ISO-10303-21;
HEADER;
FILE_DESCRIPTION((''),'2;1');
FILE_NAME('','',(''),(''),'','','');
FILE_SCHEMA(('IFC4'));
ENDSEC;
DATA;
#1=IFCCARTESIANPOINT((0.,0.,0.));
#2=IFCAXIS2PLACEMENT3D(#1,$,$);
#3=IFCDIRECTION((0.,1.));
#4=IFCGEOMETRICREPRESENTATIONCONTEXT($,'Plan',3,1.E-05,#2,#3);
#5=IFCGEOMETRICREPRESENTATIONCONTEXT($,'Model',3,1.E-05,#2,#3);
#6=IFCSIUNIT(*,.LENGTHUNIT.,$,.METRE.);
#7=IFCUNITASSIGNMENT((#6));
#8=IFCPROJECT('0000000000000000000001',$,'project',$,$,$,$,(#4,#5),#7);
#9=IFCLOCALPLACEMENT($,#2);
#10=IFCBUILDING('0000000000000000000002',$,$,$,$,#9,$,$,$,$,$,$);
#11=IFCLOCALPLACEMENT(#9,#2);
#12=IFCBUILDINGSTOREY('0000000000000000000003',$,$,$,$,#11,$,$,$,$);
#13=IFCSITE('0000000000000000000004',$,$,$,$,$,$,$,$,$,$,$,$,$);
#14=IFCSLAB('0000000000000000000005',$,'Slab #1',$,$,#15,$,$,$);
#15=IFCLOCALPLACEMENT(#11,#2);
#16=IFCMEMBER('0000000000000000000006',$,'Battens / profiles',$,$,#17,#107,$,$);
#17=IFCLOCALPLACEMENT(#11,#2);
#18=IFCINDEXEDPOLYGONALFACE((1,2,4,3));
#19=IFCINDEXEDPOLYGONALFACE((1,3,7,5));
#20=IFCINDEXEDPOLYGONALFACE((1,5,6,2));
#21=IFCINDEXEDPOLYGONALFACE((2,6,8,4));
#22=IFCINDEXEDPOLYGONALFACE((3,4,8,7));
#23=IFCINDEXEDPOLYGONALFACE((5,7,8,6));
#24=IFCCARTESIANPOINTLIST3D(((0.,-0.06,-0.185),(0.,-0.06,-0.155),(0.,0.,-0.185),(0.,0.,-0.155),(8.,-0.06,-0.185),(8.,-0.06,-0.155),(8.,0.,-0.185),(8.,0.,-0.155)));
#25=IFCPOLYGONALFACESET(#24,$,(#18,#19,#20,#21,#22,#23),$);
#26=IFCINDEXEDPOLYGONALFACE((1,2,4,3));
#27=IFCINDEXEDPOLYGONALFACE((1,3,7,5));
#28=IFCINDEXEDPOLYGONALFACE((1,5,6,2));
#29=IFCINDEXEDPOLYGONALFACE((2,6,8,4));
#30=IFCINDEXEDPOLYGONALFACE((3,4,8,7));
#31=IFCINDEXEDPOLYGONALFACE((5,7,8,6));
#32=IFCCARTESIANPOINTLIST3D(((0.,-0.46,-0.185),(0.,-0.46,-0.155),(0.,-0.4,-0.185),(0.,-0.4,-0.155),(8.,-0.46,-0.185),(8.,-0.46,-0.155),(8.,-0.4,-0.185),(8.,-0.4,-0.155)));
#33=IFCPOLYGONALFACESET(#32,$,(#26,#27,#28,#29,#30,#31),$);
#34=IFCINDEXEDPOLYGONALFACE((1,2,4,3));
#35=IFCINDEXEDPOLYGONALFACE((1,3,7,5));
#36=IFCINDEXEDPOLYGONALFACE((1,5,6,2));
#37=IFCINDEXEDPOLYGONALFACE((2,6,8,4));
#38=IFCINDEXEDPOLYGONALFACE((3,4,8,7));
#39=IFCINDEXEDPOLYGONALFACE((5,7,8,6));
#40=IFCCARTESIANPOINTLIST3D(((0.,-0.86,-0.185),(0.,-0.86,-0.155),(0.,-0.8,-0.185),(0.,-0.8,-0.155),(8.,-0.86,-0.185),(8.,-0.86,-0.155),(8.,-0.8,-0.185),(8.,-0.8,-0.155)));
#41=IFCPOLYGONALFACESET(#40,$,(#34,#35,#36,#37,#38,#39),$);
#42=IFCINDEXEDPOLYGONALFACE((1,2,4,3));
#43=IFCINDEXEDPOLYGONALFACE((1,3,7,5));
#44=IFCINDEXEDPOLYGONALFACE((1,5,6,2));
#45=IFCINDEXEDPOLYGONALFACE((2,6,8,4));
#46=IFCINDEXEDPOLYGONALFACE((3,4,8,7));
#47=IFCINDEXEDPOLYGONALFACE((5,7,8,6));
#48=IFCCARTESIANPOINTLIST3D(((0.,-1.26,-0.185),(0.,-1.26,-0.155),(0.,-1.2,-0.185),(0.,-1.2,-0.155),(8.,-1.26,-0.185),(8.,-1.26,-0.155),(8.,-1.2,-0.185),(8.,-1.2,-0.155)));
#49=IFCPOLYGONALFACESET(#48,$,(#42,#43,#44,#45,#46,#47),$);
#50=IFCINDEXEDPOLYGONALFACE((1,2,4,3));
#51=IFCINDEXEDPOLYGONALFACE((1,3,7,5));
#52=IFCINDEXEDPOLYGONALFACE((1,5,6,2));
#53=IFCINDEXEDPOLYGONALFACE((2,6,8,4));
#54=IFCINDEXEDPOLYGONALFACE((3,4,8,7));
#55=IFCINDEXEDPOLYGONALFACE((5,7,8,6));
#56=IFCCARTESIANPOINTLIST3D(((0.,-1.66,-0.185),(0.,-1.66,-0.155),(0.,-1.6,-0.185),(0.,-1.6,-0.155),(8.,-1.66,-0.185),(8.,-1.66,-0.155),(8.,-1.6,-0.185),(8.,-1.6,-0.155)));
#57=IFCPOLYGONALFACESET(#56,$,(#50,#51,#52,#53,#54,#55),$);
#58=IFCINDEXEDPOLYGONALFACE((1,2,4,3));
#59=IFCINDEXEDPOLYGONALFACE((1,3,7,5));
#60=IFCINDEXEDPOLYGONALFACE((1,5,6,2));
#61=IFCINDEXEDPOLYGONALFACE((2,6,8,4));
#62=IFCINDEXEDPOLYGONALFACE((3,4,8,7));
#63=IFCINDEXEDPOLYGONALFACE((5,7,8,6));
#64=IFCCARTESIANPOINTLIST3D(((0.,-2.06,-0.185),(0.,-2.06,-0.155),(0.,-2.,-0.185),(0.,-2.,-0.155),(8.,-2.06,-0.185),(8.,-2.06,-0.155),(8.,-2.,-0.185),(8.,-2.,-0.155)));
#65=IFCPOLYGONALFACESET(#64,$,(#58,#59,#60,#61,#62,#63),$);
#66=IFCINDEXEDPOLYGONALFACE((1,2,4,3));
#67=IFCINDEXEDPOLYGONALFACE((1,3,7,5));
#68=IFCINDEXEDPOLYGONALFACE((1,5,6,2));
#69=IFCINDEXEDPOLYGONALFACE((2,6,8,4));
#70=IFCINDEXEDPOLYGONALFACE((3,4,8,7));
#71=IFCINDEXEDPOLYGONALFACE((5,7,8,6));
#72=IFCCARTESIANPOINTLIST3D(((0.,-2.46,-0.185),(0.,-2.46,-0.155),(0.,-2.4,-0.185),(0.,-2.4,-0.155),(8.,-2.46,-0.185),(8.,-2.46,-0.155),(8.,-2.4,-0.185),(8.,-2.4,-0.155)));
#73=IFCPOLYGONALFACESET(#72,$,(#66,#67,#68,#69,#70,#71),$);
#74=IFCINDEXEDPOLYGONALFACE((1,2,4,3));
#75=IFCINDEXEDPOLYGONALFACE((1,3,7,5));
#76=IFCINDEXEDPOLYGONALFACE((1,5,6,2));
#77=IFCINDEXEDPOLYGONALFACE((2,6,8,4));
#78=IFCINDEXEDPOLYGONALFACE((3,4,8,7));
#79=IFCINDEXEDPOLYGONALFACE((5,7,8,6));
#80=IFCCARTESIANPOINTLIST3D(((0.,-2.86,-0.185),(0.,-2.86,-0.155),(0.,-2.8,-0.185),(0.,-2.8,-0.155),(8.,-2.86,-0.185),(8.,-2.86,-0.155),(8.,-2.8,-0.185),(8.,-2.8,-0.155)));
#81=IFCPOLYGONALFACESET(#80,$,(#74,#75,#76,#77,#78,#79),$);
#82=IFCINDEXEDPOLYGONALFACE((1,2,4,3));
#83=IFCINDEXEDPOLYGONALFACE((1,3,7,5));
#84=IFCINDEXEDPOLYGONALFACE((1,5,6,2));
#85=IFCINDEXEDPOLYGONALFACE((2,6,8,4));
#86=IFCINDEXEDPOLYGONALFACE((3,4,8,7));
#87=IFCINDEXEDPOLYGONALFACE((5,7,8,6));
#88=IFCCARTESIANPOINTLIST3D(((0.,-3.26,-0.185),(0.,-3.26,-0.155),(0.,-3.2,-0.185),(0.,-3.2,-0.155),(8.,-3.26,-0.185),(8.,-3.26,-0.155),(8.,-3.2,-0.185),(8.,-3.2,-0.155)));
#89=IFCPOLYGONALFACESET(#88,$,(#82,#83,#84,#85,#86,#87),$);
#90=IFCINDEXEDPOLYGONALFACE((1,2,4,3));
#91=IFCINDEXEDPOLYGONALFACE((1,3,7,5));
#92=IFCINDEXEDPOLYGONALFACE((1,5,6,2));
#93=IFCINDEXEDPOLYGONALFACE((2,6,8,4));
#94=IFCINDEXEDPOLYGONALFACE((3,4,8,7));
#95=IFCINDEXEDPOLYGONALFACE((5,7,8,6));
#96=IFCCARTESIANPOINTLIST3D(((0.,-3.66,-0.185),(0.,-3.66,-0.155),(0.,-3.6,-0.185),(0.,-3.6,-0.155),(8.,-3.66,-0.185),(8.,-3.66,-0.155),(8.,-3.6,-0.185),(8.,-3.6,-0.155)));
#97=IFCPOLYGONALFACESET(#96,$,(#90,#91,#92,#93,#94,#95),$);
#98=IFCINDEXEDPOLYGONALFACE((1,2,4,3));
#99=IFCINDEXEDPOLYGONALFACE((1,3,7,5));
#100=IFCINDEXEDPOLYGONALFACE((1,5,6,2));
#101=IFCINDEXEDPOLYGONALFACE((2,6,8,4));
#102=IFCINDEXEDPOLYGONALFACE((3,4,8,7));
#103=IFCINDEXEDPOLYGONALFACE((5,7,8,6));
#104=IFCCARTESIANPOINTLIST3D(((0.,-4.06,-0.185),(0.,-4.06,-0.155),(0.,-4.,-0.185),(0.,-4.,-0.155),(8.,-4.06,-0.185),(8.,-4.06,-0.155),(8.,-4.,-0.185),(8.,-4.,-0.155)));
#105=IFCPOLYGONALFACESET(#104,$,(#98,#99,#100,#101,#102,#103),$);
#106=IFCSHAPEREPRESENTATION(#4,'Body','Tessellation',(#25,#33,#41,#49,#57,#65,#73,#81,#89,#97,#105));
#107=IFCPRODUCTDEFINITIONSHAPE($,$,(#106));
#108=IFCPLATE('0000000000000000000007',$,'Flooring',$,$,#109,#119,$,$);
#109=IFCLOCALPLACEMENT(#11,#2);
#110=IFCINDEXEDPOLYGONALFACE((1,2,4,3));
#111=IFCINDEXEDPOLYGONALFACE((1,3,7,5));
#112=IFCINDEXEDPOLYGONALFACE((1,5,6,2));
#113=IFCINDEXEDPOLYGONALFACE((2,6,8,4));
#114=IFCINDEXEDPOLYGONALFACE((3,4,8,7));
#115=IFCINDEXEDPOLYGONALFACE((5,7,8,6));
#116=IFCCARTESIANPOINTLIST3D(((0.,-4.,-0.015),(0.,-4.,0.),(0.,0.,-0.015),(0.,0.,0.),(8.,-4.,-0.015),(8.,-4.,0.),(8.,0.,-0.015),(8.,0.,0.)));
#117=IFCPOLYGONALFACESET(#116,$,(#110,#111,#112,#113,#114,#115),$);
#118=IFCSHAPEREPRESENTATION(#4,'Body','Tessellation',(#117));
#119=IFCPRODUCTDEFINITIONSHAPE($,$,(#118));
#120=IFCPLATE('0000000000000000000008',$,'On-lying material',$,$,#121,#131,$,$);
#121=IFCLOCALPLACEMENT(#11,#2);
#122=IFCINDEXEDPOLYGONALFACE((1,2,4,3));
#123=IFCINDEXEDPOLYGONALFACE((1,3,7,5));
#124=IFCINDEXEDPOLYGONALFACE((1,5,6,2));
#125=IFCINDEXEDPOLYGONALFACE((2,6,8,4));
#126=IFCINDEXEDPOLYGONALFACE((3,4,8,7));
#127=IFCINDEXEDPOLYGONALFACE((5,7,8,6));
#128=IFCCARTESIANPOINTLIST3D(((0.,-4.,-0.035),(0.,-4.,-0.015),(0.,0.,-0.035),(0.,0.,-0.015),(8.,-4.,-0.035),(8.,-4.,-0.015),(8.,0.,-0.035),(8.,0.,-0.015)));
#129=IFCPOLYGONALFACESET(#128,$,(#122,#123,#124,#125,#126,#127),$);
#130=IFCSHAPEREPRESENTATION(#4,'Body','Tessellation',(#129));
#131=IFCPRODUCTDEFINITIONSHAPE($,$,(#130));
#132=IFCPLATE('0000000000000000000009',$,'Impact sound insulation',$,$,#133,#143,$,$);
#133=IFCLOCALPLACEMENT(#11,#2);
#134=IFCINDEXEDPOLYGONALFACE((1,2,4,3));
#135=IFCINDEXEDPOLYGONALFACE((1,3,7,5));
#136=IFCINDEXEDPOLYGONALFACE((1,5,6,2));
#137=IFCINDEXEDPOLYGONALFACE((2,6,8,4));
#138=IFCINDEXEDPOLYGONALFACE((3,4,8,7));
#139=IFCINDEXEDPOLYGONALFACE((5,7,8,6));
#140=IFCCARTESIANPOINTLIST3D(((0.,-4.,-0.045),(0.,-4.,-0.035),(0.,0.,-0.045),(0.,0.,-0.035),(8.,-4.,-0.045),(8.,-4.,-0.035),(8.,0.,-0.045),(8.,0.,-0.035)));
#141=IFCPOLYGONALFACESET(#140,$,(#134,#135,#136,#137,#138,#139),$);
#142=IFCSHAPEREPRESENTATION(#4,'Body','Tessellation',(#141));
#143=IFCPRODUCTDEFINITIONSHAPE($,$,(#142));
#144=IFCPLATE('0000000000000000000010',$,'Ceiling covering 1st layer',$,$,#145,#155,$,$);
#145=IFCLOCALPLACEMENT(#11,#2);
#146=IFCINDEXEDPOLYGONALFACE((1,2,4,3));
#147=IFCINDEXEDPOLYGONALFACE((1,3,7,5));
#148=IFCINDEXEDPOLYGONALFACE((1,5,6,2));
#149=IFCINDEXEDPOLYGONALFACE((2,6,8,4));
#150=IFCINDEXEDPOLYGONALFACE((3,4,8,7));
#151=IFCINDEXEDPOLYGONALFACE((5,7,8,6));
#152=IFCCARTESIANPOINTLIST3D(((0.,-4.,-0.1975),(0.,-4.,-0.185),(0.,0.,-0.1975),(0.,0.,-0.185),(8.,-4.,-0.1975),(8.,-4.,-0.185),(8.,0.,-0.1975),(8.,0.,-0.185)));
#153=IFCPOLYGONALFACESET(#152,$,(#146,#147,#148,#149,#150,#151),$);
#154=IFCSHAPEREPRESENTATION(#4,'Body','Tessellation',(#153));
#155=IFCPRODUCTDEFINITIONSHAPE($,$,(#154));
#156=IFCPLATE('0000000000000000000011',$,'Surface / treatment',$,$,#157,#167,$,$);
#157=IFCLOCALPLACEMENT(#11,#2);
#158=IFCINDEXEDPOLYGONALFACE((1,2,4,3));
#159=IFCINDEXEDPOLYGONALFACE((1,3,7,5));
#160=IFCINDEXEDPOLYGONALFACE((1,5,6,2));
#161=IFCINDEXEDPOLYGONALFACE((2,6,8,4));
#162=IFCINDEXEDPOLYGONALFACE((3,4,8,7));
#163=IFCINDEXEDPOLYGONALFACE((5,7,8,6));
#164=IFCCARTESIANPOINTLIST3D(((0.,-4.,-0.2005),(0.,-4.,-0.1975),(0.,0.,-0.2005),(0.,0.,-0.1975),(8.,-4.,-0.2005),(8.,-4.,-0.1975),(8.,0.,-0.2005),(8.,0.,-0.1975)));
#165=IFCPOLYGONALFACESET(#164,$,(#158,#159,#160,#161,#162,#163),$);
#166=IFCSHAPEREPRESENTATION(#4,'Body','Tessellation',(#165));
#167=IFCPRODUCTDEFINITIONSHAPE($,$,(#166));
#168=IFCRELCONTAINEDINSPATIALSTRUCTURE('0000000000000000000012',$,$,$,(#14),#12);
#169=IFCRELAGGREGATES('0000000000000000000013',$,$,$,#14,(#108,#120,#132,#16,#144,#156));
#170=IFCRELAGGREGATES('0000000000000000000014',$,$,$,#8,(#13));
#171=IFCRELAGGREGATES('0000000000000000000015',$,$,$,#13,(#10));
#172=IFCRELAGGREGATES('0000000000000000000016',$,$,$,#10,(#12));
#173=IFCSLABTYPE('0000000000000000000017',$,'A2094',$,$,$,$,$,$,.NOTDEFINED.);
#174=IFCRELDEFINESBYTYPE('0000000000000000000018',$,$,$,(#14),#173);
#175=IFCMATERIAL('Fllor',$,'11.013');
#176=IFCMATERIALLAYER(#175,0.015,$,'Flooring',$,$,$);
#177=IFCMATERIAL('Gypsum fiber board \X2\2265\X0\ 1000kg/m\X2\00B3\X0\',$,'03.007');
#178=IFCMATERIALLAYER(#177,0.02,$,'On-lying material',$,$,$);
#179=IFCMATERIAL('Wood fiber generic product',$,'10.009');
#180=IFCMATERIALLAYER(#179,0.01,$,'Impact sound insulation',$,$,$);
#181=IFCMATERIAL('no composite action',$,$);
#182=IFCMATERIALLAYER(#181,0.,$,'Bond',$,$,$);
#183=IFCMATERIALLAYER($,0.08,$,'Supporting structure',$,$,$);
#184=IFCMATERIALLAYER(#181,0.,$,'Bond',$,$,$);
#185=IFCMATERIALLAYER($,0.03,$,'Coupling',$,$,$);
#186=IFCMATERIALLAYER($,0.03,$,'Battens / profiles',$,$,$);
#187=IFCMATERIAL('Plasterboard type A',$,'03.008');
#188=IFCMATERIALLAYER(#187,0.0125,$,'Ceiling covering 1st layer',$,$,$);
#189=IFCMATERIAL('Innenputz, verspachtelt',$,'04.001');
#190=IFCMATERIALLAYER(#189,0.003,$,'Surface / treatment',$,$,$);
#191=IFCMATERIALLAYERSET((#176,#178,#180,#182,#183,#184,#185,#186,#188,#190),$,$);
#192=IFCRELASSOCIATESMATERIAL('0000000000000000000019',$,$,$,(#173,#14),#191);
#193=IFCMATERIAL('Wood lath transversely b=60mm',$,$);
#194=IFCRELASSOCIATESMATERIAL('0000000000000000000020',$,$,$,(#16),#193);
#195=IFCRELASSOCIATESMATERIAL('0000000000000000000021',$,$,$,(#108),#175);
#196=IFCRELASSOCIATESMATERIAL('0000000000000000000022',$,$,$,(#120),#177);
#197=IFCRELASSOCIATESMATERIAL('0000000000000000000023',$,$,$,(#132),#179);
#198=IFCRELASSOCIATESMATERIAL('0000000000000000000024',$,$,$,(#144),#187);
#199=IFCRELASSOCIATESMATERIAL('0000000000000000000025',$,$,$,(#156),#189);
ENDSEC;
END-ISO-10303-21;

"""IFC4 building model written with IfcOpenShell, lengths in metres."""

from ifc_helpers import new_model, si_unit, direction, frame, frame_2d, origin, origin_with_axes, place, context, project, spatial, rectangle, extrude, material, layer, layer_set, type_object, element, aggregate, save


model = new_model("IFC4")

# Units and contexts
plan_context = context("Plan", 3, precision=1e-05, world=origin(), true_north=direction((0.0, 1.0)))
model_context = context("Model", 3, precision=1e-05, world=origin(), true_north=direction((0.0, 1.0)))
ifc_project = project(units=[si_unit("LENGTHUNIT", "METRE")], contexts=[plan_context, model_context])

# Site, building, storey
site = spatial("IfcSite", under=ifc_project)
building_placement = place(None, origin())
building = spatial("IfcBuilding", under=site, at=building_placement)
storey_placement = place(building_placement, origin())
storey = spatial("IfcBuildingStorey", under=building, at=storey_placement)

# Slab, member, plates
ifc_material_1 = material(Name="Fllor", Category="11.013")
ifc_layer_1 = layer(ifc_material_1, 0.015, Name="Flooring")
ifc_material_2 = material(Name="Gypsum fiber board ≥ 1000kg/m³", Category="03.007")
ifc_layer_2 = layer(ifc_material_2, 0.02, Name="On-lying material")
ifc_material_3 = material(Name="Wood fiber generic product", Category="10.009")
ifc_layer_3 = layer(ifc_material_3, 0.01, Name="Impact sound insulation")
ifc_material_4 = material(Name="no composite action")
ifc_layer_4 = layer(ifc_material_4, 0.0, Name="Bond")
ifc_layer_5 = layer(None, 0.08, Name="Supporting structure")
ifc_layer_6 = layer(ifc_material_4, 0.0, Name="Bond")
ifc_layer_7 = layer(None, 0.03, Name="Coupling")
ifc_layer_8 = layer(None, 0.03, Name="Battens / profiles")
ifc_material_5 = material(Name="Plasterboard type A", Category="03.008")
ifc_layer_9 = layer(ifc_material_5, 0.0125, Name="Ceiling covering 1st layer")
ifc_material_6 = material(Name="Innenputz, verspachtelt", Category="04.001")
ifc_layer_10 = layer(ifc_material_6, 0.003, Name="Surface / treatment")
ifc_layer_set = layer_set([ifc_layer_1, ifc_layer_2, ifc_layer_3, ifc_layer_4, ifc_layer_5, ifc_layer_6, ifc_layer_7, ifc_layer_8, ifc_layer_9, ifc_layer_10])
slab_type = type_object("IfcSlabType", Name="A2094", PredefinedType="NOTDEFINED", material=ifc_layer_set)
slab_placement = place(None, frame((0.0, 0.0, 0.0), z_axis=(0.0, 0.0, -1.0), x_axis=(1.0, 0.0, 0.0)))
slab = element("IfcSlab", 1, at=slab_placement, inside=storey, type_object=slab_type, material=ifc_layer_set, Name="Slab #1")
ifc_material_7 = material(Name="Wood lath transversely b=60mm")
member_1_placement = place(slab_placement, origin())
member_1 = element("IfcMember", 2, at=member_1_placement, material=ifc_material_7, Name="Battens / profiles", context=plan_context, shape_type="SweptSolid", body=[
    extrude(rectangle(XDim=0.06, YDim=0.03, at=frame_2d((0.03, 0.015), x_axis=(1.0, 0.0))), frame((0.0, 0.0, 0.155), z_axis=(1.0, 0.0, 0.0), x_axis=(0.0, 1.0, 0.0)), (0.0, 0.0, 1.0), 8.0),
    extrude(rectangle(XDim=0.06, YDim=0.03, at=frame_2d((0.03, 0.015), x_axis=(1.0, 0.0))), frame((0.0, 0.4, 0.155), z_axis=(1.0, 0.0, 0.0), x_axis=(0.0, 1.0, 0.0)), (0.0, 0.0, 1.0), 8.0),
    extrude(rectangle(XDim=0.06, YDim=0.03, at=frame_2d((0.03, 0.015), x_axis=(1.0, 0.0))), frame((0.0, 0.8, 0.155), z_axis=(1.0, 0.0, 0.0), x_axis=(0.0, 1.0, 0.0)), (0.0, 0.0, 1.0), 8.0),
    extrude(rectangle(XDim=0.06, YDim=0.03, at=frame_2d((0.03, 0.015), x_axis=(1.0, 0.0))), frame((0.0, 1.2, 0.155), z_axis=(1.0, 0.0, 0.0), x_axis=(0.0, 1.0, 0.0)), (0.0, 0.0, 1.0), 8.0),
    extrude(rectangle(XDim=0.06, YDim=0.03, at=frame_2d((0.03, 0.015), x_axis=(1.0, 0.0))), frame((0.0, 1.6, 0.155), z_axis=(1.0, 0.0, 0.0), x_axis=(0.0, 1.0, 0.0)), (0.0, 0.0, 1.0), 8.0),
    extrude(rectangle(XDim=0.06, YDim=0.03, at=frame_2d((0.03, 0.015), x_axis=(1.0, 0.0))), frame((0.0, 2.0, 0.155), z_axis=(1.0, 0.0, 0.0), x_axis=(0.0, 1.0, 0.0)), (0.0, 0.0, 1.0), 8.0),
    extrude(rectangle(XDim=0.06, YDim=0.03, at=frame_2d((0.03, 0.015), x_axis=(1.0, 0.0))), frame((0.0, 2.4, 0.155), z_axis=(1.0, 0.0, 0.0), x_axis=(0.0, 1.0, 0.0)), (0.0, 0.0, 1.0), 8.0),
    extrude(rectangle(XDim=0.06, YDim=0.03, at=frame_2d((0.03, 0.015), x_axis=(1.0, 0.0))), frame((0.0, 2.8, 0.155), z_axis=(1.0, 0.0, 0.0), x_axis=(0.0, 1.0, 0.0)), (0.0, 0.0, 1.0), 8.0),
    extrude(rectangle(XDim=0.06, YDim=0.03, at=frame_2d((0.03, 0.015), x_axis=(1.0, 0.0))), frame((0.0, 3.2, 0.155), z_axis=(1.0, 0.0, 0.0), x_axis=(0.0, 1.0, 0.0)), (0.0, 0.0, 1.0), 8.0),
    extrude(rectangle(XDim=0.06, YDim=0.03, at=frame_2d((0.03, 0.015), x_axis=(1.0, 0.0))), frame((0.0, 3.6, 0.155), z_axis=(1.0, 0.0, 0.0), x_axis=(0.0, 1.0, 0.0)), (0.0, 0.0, 1.0), 8.0),
    extrude(rectangle(XDim=0.06, YDim=0.03, at=frame_2d((0.03, 0.015), x_axis=(1.0, 0.0))), frame((0.0, 4.0, 0.155), z_axis=(1.0, 0.0, 0.0), x_axis=(0.0, 1.0, 0.0)), (0.0, 0.0, 1.0), 8.0),
])
plate_1_placement = place(slab_placement, origin())
plate_1 = element("IfcPlate", 3, at=plate_1_placement, material=ifc_material_1, Name="Flooring", context=plan_context, shape_type="SweptSolid", body=[
    extrude(rectangle(XDim=8.0, YDim=4.0, at=frame_2d((4.0, 2.0), x_axis=(1.0, 0.0))), origin_with_axes(), (0.0, 0.0, 1.0), 0.015),
])
plate_2_placement = place(slab_placement, origin())
plate_2 = element("IfcPlate", 4, at=plate_2_placement, material=ifc_material_2, Name="On-lying material", context=plan_context, shape_type="SweptSolid", body=[
    extrude(rectangle(XDim=8.0, YDim=4.0, at=frame_2d((4.0, 2.0), x_axis=(1.0, 0.0))), frame((0.0, 0.0, 0.015), z_axis=(0.0, 0.0, 1.0), x_axis=(1.0, 0.0, 0.0)), (0.0, 0.0, 1.0), 0.02),
])
plate_3_placement = place(slab_placement, origin())
plate_3 = element("IfcPlate", 5, at=plate_3_placement, material=ifc_material_3, Name="Impact sound insulation", context=plan_context, shape_type="SweptSolid", body=[
    extrude(rectangle(XDim=8.0, YDim=4.0, at=frame_2d((4.0, 2.0), x_axis=(1.0, 0.0))), frame((0.0, 0.0, 0.035), z_axis=(0.0, 0.0, 1.0), x_axis=(1.0, 0.0, 0.0)), (0.0, 0.0, 1.0), 0.01),
])
plate_4_placement = place(slab_placement, origin())
plate_4 = element("IfcPlate", 6, at=plate_4_placement, material=ifc_material_5, Name="Ceiling covering 1st layer", context=plan_context, shape_type="SweptSolid", body=[
    extrude(rectangle(XDim=8.0, YDim=4.0, at=frame_2d((4.0, 2.0), x_axis=(1.0, 0.0))), frame((0.0, 0.0, 0.185), z_axis=(0.0, 0.0, 1.0), x_axis=(1.0, 0.0, 0.0)), (0.0, 0.0, 1.0), 0.0125),
])
plate_5_placement = place(slab_placement, origin())
plate_5 = element("IfcPlate", 7, at=plate_5_placement, material=ifc_material_6, Name="Surface / treatment", context=plan_context, shape_type="SweptSolid", body=[
    extrude(rectangle(XDim=8.0, YDim=4.0, at=frame_2d((4.0, 2.0), x_axis=(1.0, 0.0))), frame((0.0, 0.0, 0.1975), z_axis=(0.0, 0.0, 1.0), x_axis=(1.0, 0.0, 0.0)), (0.0, 0.0, 1.0), 0.003),
])
aggregate(slab, [plate_1, plate_2, plate_3, member_1, plate_4, plate_5])

save(model, "model.ifc")
